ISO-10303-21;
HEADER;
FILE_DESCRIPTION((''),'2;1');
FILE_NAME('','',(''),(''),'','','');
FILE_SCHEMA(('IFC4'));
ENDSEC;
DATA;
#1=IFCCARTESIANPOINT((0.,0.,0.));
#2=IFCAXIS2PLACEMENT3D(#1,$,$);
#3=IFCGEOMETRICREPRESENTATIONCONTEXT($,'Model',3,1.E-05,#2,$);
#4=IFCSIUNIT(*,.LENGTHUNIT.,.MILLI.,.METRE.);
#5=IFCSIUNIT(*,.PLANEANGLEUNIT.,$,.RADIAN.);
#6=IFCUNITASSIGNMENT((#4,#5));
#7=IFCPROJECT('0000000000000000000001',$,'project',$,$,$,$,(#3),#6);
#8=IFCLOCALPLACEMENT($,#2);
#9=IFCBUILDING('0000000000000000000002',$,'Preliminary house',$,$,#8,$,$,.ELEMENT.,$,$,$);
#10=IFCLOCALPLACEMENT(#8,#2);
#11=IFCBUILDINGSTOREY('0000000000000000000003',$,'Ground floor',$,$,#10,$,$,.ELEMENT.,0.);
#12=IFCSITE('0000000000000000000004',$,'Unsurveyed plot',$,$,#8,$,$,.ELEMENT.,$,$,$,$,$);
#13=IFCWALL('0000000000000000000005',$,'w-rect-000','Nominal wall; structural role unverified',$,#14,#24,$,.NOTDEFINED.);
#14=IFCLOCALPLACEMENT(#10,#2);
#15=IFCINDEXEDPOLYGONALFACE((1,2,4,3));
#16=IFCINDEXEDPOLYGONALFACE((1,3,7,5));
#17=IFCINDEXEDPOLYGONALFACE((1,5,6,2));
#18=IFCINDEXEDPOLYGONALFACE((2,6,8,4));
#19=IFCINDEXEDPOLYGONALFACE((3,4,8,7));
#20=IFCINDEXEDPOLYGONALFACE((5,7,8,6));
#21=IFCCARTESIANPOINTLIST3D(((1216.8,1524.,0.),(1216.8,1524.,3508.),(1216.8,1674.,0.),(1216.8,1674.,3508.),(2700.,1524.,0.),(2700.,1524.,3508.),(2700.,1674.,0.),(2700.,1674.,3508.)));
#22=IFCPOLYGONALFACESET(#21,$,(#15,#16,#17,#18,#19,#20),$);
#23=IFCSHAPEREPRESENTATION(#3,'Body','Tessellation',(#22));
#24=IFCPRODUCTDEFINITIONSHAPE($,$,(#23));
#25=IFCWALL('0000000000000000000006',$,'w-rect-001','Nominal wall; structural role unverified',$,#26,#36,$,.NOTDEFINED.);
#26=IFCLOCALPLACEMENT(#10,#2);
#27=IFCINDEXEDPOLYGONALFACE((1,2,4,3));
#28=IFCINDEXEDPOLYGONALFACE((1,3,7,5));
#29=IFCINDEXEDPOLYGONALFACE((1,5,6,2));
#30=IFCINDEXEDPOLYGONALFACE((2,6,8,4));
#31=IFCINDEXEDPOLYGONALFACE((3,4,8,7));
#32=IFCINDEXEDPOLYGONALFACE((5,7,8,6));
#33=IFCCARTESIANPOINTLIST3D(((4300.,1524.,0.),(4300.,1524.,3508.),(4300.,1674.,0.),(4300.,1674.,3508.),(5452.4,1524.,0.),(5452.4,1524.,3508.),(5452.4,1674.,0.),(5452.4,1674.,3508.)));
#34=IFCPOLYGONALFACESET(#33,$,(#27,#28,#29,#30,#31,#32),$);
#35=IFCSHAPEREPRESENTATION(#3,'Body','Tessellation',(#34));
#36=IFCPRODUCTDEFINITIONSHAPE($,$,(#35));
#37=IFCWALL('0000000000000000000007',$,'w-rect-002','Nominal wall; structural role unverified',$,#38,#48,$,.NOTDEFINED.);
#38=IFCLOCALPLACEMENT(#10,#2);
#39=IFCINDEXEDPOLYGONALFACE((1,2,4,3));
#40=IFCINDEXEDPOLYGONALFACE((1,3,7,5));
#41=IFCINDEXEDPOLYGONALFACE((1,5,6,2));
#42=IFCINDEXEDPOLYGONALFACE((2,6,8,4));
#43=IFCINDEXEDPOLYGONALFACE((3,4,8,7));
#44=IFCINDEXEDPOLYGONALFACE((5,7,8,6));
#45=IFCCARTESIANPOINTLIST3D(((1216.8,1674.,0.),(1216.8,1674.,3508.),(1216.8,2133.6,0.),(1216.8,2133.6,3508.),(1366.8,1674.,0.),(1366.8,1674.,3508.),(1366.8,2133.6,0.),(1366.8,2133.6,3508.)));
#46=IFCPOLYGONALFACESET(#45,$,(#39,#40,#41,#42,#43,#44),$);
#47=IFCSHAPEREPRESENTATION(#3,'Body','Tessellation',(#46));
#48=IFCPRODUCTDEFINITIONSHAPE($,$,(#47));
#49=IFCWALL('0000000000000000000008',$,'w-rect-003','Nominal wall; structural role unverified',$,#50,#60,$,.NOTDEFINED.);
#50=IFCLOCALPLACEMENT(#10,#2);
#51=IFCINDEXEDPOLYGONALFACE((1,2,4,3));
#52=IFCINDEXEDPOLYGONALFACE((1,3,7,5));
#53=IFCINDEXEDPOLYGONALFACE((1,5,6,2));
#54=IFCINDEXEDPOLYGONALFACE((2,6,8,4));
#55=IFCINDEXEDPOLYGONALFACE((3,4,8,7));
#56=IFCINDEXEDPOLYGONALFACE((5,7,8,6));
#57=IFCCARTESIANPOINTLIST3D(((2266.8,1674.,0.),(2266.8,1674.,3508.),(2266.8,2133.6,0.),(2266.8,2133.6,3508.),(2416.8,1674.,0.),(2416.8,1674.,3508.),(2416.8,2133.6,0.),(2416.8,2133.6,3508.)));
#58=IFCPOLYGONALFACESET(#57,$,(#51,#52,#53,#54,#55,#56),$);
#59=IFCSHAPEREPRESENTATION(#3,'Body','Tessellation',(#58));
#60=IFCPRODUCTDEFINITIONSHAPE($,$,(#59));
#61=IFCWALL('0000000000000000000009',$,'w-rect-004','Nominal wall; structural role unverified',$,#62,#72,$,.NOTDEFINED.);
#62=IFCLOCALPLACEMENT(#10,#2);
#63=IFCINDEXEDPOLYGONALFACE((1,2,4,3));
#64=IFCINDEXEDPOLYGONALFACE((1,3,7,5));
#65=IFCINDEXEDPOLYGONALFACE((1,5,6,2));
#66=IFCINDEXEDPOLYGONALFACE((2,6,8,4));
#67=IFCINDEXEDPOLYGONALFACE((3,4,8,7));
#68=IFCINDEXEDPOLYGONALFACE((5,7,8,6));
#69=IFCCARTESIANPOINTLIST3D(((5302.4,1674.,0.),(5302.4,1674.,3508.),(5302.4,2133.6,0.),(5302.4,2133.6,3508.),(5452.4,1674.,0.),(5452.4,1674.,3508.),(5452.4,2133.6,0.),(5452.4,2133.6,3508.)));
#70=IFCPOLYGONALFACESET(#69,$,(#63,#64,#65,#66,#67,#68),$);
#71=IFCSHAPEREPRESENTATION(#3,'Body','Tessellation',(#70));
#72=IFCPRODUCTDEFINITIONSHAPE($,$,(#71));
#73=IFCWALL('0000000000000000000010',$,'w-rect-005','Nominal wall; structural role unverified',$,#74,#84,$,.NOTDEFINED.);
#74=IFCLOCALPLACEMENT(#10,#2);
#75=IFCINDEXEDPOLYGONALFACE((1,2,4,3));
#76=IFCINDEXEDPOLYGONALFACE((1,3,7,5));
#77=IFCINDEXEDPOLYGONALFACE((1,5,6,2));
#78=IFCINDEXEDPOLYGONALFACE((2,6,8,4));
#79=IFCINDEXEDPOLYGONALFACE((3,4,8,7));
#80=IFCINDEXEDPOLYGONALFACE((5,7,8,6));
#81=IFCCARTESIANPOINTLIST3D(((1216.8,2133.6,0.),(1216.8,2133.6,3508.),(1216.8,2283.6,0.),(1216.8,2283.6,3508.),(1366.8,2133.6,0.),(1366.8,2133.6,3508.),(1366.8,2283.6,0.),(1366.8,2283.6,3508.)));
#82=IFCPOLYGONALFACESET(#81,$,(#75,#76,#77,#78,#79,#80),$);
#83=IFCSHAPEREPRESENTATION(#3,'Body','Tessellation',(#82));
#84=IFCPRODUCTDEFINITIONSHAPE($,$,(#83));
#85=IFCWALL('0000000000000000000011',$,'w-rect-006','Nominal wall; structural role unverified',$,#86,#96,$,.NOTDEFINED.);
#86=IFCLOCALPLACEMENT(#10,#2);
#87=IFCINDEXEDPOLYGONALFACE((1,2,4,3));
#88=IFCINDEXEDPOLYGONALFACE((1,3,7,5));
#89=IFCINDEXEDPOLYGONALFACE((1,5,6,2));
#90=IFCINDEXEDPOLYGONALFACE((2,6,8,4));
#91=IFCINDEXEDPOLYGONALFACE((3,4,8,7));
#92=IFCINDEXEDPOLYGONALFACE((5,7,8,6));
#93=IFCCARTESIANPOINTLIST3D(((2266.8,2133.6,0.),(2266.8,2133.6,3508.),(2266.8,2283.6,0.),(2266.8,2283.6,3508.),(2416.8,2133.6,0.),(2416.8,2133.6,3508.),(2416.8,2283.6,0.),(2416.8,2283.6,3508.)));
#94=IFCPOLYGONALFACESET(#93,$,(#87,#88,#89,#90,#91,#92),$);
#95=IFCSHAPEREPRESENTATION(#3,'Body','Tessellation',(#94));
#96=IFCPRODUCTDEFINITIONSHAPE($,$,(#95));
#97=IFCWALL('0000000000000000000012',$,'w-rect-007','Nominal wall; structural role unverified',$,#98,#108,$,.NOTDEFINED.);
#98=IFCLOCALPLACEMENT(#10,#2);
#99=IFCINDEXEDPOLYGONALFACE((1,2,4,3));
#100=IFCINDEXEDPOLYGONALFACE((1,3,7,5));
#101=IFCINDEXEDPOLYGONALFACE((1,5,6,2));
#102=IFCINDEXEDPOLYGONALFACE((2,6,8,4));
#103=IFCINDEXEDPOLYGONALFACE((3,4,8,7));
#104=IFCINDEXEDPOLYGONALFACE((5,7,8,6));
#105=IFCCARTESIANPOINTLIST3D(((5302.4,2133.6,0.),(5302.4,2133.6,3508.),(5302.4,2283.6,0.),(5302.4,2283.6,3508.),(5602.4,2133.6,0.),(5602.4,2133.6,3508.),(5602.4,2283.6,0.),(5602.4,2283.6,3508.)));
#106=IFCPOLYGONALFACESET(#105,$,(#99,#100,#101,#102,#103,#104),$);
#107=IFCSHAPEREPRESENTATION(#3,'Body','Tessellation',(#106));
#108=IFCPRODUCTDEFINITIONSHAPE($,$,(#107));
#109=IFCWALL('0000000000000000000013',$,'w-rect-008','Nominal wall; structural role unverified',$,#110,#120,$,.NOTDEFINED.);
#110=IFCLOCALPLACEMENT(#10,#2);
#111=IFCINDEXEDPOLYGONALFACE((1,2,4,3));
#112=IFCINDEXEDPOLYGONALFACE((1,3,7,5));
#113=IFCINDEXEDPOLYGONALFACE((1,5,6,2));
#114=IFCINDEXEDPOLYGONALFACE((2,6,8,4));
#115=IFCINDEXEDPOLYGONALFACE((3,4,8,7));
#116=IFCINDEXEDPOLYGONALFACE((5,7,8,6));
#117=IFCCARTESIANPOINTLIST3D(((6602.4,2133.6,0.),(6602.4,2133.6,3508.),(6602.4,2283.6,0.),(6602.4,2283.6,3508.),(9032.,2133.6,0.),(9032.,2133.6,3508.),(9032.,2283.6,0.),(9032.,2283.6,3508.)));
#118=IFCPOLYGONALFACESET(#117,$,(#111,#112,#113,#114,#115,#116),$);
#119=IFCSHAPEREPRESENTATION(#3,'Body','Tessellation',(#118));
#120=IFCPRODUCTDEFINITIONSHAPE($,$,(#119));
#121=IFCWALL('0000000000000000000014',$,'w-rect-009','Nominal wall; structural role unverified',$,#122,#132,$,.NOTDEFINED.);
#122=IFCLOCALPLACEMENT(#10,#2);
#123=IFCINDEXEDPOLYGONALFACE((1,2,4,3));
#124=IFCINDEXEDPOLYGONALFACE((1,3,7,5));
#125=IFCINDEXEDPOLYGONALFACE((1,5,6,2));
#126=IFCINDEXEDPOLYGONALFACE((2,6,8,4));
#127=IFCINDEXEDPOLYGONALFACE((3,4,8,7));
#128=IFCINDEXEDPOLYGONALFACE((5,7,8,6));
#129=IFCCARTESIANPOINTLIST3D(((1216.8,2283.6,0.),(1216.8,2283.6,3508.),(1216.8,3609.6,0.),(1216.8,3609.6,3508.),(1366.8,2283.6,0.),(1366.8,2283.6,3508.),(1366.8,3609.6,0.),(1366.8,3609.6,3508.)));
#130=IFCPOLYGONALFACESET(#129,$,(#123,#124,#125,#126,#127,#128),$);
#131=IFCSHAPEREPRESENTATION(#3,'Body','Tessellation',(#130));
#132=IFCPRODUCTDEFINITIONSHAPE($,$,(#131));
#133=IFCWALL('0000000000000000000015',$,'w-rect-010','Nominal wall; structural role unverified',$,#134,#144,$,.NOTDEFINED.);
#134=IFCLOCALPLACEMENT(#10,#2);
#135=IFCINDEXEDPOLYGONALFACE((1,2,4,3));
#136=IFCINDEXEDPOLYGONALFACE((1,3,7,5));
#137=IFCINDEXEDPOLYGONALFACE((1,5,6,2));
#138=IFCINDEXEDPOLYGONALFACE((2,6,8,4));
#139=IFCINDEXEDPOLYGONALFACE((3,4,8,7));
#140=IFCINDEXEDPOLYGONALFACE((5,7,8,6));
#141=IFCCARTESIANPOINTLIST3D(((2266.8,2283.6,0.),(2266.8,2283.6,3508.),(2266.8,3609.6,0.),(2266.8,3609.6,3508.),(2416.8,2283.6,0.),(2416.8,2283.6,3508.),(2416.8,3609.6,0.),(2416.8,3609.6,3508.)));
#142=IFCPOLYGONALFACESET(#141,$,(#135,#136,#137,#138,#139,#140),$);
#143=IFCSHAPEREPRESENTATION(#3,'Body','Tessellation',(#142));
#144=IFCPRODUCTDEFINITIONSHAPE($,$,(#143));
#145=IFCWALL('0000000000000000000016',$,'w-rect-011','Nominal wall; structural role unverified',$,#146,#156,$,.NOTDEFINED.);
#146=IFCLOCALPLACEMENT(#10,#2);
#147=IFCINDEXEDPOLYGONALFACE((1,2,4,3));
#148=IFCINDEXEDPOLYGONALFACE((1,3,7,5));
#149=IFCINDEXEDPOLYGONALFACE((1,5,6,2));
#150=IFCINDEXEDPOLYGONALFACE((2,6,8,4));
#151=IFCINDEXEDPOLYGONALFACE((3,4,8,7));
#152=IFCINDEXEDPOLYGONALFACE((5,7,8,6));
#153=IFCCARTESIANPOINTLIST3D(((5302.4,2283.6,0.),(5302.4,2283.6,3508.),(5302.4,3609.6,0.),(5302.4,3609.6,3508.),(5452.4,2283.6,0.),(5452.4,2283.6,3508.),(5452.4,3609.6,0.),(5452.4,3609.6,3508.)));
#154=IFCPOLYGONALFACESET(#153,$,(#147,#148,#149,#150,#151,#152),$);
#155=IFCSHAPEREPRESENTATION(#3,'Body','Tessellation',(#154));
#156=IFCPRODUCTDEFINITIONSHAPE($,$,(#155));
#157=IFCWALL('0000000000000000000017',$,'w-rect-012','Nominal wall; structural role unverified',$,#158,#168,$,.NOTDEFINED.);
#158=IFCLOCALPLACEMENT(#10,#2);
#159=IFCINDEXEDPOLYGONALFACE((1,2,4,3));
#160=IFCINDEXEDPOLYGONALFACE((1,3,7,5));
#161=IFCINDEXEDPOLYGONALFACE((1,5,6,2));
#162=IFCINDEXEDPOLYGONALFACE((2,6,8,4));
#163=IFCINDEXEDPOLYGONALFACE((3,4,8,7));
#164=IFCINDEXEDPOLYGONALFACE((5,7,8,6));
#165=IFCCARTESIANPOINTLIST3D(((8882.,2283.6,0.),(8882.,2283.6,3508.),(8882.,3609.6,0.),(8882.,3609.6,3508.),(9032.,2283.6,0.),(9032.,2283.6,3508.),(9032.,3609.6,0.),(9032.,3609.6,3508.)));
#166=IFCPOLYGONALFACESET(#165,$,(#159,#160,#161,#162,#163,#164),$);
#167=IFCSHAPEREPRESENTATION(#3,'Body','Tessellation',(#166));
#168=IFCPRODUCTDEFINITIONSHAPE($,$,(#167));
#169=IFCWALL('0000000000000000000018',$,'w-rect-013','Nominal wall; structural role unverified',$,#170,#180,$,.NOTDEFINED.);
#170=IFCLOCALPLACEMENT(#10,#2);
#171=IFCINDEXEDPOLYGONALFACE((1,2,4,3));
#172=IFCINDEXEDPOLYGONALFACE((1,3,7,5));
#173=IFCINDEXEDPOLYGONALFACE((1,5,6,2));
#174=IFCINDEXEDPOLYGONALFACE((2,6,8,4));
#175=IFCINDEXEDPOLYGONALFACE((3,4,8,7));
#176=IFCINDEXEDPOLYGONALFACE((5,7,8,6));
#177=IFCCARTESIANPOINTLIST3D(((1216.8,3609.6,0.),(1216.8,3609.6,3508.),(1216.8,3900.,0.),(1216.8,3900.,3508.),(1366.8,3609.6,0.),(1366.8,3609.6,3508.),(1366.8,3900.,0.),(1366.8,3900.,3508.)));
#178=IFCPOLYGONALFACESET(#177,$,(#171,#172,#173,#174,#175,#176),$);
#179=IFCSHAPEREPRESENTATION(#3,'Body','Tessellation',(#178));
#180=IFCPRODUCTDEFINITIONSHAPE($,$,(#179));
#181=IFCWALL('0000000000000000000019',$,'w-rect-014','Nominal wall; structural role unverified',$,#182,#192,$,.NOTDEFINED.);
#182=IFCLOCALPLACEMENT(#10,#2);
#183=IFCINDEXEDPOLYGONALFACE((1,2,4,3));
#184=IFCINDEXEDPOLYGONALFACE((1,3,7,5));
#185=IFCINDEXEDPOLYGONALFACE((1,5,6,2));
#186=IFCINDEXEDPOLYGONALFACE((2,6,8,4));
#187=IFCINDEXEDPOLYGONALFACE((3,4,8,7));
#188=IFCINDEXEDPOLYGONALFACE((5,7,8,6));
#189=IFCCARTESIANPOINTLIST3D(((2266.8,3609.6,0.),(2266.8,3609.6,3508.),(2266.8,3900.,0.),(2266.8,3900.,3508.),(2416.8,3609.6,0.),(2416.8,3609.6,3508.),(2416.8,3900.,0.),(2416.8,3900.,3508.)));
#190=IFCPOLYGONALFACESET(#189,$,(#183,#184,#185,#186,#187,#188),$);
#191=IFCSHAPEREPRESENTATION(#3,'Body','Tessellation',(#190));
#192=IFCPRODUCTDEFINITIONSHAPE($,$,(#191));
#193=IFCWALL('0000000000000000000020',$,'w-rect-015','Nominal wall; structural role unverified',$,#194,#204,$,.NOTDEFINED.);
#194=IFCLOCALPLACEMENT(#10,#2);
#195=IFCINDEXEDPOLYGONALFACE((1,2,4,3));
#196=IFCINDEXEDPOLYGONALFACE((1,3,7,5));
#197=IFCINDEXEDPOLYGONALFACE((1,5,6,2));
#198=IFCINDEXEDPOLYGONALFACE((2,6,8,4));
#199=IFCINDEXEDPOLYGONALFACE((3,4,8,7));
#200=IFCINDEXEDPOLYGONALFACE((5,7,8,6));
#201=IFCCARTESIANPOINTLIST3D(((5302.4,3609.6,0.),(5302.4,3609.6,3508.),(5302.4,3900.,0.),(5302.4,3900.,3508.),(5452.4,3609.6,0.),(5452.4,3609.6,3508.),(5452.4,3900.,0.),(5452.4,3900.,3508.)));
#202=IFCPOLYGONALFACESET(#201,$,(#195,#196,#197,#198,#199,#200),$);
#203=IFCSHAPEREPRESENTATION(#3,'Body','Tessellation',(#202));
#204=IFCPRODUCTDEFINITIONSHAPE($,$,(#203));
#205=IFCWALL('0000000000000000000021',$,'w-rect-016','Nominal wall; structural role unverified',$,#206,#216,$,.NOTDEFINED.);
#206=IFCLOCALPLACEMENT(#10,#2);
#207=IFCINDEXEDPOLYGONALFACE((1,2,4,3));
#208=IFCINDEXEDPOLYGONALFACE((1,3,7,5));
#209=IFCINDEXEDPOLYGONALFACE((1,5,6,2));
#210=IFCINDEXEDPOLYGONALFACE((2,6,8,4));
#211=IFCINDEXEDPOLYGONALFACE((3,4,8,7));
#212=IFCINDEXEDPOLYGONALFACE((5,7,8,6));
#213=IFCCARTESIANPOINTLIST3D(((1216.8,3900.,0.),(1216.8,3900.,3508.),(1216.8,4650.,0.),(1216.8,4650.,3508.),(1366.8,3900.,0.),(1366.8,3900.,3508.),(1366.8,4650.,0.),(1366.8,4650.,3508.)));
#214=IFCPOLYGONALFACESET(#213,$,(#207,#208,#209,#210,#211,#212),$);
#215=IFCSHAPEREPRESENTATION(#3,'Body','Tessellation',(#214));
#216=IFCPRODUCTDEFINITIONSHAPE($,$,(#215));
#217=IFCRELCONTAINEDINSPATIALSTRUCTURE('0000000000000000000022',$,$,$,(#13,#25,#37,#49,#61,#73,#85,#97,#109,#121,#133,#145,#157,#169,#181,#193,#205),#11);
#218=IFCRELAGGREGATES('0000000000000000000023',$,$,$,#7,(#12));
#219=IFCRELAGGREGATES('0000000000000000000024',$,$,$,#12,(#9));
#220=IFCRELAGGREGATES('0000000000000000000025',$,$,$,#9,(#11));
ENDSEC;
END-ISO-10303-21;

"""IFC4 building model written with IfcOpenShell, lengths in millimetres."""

from ifc_helpers import new_model, si_unit, origin, place, context, project, spatial, polyline, outline, extrude, element, save


model = new_model("IFC4")

# Units and contexts
model_context = context("Model", 3, precision=1e-05, world=origin())
ifc_project = project(units=[si_unit("LENGTHUNIT", "METRE", prefix="MILLI"), si_unit("PLANEANGLEUNIT", "RADIAN")], contexts=[model_context])

# Site, building, storey
placement_1 = place(None, origin())
site = spatial("IfcSite", under=ifc_project, at=placement_1, Name="Unsurveyed plot", CompositionType="ELEMENT")
building = spatial("IfcBuilding", under=site, at=placement_1, Name="Preliminary house", CompositionType="ELEMENT")
placement_2 = place(placement_1, origin())
storey = spatial("IfcBuildingStorey", under=building, at=placement_2, Name="Ground floor", CompositionType="ELEMENT", Elevation=0.0)

# Walls
element("IfcWall", 1, at=placement_2, inside=storey, Name="w-rect-000", Description="Nominal wall; structural role unverified", PredefinedType="NOTDEFINED", context=model_context, shape_type="SweptSolid", body=[
    extrude(outline(polyline([(1216.8, 1524.0), (2700.0, 1524.0), (2700.0, 1674.0), (1216.8, 1674.0), (1216.8, 1524.0)])), origin(), (0.0, 0.0, 1.0), 3508.0),
])
element("IfcWall", 2, at=placement_2, inside=storey, Name="w-rect-001", Description="Nominal wall; structural role unverified", PredefinedType="NOTDEFINED", context=model_context, shape_type="SweptSolid", body=[
    extrude(outline(polyline([(4300.0, 1524.0), (5452.4, 1524.0), (5452.4, 1674.0), (4300.0, 1674.0), (4300.0, 1524.0)])), origin(), (0.0, 0.0, 1.0), 3508.0),
])
element("IfcWall", 3, at=placement_2, inside=storey, Name="w-rect-002", Description="Nominal wall; structural role unverified", PredefinedType="NOTDEFINED", context=model_context, shape_type="SweptSolid", body=[
    extrude(outline(polyline([(1216.8, 1674.0), (1366.8, 1674.0), (1366.8, 2133.6), (1216.8, 2133.6), (1216.8, 1674.0)])), origin(), (0.0, 0.0, 1.0), 3508.0),
])
element("IfcWall", 4, at=placement_2, inside=storey, Name="w-rect-003", Description="Nominal wall; structural role unverified", PredefinedType="NOTDEFINED", context=model_context, shape_type="SweptSolid", body=[
    extrude(outline(polyline([(2266.8, 1674.0), (2416.8, 1674.0), (2416.8, 2133.6), (2266.8, 2133.6), (2266.8, 1674.0)])), origin(), (0.0, 0.0, 1.0), 3508.0),
])
element("IfcWall", 5, at=placement_2, inside=storey, Name="w-rect-004", Description="Nominal wall; structural role unverified", PredefinedType="NOTDEFINED", context=model_context, shape_type="SweptSolid", body=[
    extrude(outline(polyline([(5302.4, 1674.0), (5452.4, 1674.0), (5452.4, 2133.6), (5302.4, 2133.6), (5302.4, 1674.0)])), origin(), (0.0, 0.0, 1.0), 3508.0),
])
element("IfcWall", 6, at=placement_2, inside=storey, Name="w-rect-005", Description="Nominal wall; structural role unverified", PredefinedType="NOTDEFINED", context=model_context, shape_type="SweptSolid", body=[
    extrude(outline(polyline([(1216.8, 2133.6), (1366.8, 2133.6), (1366.8, 2283.6), (1216.8, 2283.6), (1216.8, 2133.6)])), origin(), (0.0, 0.0, 1.0), 3508.0),
])
element("IfcWall", 7, at=placement_2, inside=storey, Name="w-rect-006", Description="Nominal wall; structural role unverified", PredefinedType="NOTDEFINED", context=model_context, shape_type="SweptSolid", body=[
    extrude(outline(polyline([(2266.8, 2133.6), (2416.8, 2133.6), (2416.8, 2283.6), (2266.8, 2283.6), (2266.8, 2133.6)])), origin(), (0.0, 0.0, 1.0), 3508.0),
])
element("IfcWall", 8, at=placement_2, inside=storey, Name="w-rect-007", Description="Nominal wall; structural role unverified", PredefinedType="NOTDEFINED", context=model_context, shape_type="SweptSolid", body=[
    extrude(outline(polyline([(5302.4, 2133.6), (5602.4, 2133.6), (5602.4, 2283.6), (5302.4, 2283.6), (5302.4, 2133.6)])), origin(), (0.0, 0.0, 1.0), 3508.0),
])
element("IfcWall", 9, at=placement_2, inside=storey, Name="w-rect-008", Description="Nominal wall; structural role unverified", PredefinedType="NOTDEFINED", context=model_context, shape_type="SweptSolid", body=[
    extrude(outline(polyline([(6602.4, 2133.6), (9032.0, 2133.6), (9032.0, 2283.6), (6602.4, 2283.6), (6602.4, 2133.6)])), origin(), (0.0, 0.0, 1.0), 3508.0),
])
element("IfcWall", 10, at=placement_2, inside=storey, Name="w-rect-009", Description="Nominal wall; structural role unverified", PredefinedType="NOTDEFINED", context=model_context, shape_type="SweptSolid", body=[
    extrude(outline(polyline([(1216.8, 2283.6), (1366.8, 2283.6), (1366.8, 3609.6), (1216.8, 3609.6), (1216.8, 2283.6)])), origin(), (0.0, 0.0, 1.0), 3508.0),
])
element("IfcWall", 11, at=placement_2, inside=storey, Name="w-rect-010", Description="Nominal wall; structural role unverified", PredefinedType="NOTDEFINED", context=model_context, shape_type="SweptSolid", body=[
    extrude(outline(polyline([(2266.8, 2283.6), (2416.8, 2283.6), (2416.8, 3609.6), (2266.8, 3609.6), (2266.8, 2283.6)])), origin(), (0.0, 0.0, 1.0), 3508.0),
])
element("IfcWall", 12, at=placement_2, inside=storey, Name="w-rect-011", Description="Nominal wall; structural role unverified", PredefinedType="NOTDEFINED", context=model_context, shape_type="SweptSolid", body=[
    extrude(outline(polyline([(5302.4, 2283.6), (5452.4, 2283.6), (5452.4, 3609.6), (5302.4, 3609.6), (5302.4, 2283.6)])), origin(), (0.0, 0.0, 1.0), 3508.0),
])
element("IfcWall", 13, at=placement_2, inside=storey, Name="w-rect-012", Description="Nominal wall; structural role unverified", PredefinedType="NOTDEFINED", context=model_context, shape_type="SweptSolid", body=[
    extrude(outline(polyline([(8882.0, 2283.6), (9032.0, 2283.6), (9032.0, 3609.6), (8882.0, 3609.6), (8882.0, 2283.6)])), origin(), (0.0, 0.0, 1.0), 3508.0),
])
element("IfcWall", 14, at=placement_2, inside=storey, Name="w-rect-013", Description="Nominal wall; structural role unverified", PredefinedType="NOTDEFINED", context=model_context, shape_type="SweptSolid", body=[
    extrude(outline(polyline([(1216.8, 3609.6), (1366.8, 3609.6), (1366.8, 3900.0), (1216.8, 3900.0), (1216.8, 3609.6)])), origin(), (0.0, 0.0, 1.0), 3508.0),
])
element("IfcWall", 15, at=placement_2, inside=storey, Name="w-rect-014", Description="Nominal wall; structural role unverified", PredefinedType="NOTDEFINED", context=model_context, shape_type="SweptSolid", body=[
    extrude(outline(polyline([(2266.8, 3609.6), (2416.8, 3609.6), (2416.8, 3900.0), (2266.8, 3900.0), (2266.8, 3609.6)])), origin(), (0.0, 0.0, 1.0), 3508.0),
])
element("IfcWall", 16, at=placement_2, inside=storey, Name="w-rect-015", Description="Nominal wall; structural role unverified", PredefinedType="NOTDEFINED", context=model_context, shape_type="SweptSolid", body=[
    extrude(outline(polyline([(5302.4, 3609.6), (5452.4, 3609.6), (5452.4, 3900.0), (5302.4, 3900.0), (5302.4, 3609.6)])), origin(), (0.0, 0.0, 1.0), 3508.0),
])
element("IfcWall", 17, at=placement_2, inside=storey, Name="w-rect-016", Description="Nominal wall; structural role unverified", PredefinedType="NOTDEFINED", context=model_context, shape_type="SweptSolid", body=[
    extrude(outline(polyline([(1216.8, 3900.0), (1366.8, 3900.0), (1366.8, 4650.0), (1216.8, 4650.0), (1216.8, 3900.0)])), origin(), (0.0, 0.0, 1.0), 3508.0),
])

save(model, "model.ifc")
